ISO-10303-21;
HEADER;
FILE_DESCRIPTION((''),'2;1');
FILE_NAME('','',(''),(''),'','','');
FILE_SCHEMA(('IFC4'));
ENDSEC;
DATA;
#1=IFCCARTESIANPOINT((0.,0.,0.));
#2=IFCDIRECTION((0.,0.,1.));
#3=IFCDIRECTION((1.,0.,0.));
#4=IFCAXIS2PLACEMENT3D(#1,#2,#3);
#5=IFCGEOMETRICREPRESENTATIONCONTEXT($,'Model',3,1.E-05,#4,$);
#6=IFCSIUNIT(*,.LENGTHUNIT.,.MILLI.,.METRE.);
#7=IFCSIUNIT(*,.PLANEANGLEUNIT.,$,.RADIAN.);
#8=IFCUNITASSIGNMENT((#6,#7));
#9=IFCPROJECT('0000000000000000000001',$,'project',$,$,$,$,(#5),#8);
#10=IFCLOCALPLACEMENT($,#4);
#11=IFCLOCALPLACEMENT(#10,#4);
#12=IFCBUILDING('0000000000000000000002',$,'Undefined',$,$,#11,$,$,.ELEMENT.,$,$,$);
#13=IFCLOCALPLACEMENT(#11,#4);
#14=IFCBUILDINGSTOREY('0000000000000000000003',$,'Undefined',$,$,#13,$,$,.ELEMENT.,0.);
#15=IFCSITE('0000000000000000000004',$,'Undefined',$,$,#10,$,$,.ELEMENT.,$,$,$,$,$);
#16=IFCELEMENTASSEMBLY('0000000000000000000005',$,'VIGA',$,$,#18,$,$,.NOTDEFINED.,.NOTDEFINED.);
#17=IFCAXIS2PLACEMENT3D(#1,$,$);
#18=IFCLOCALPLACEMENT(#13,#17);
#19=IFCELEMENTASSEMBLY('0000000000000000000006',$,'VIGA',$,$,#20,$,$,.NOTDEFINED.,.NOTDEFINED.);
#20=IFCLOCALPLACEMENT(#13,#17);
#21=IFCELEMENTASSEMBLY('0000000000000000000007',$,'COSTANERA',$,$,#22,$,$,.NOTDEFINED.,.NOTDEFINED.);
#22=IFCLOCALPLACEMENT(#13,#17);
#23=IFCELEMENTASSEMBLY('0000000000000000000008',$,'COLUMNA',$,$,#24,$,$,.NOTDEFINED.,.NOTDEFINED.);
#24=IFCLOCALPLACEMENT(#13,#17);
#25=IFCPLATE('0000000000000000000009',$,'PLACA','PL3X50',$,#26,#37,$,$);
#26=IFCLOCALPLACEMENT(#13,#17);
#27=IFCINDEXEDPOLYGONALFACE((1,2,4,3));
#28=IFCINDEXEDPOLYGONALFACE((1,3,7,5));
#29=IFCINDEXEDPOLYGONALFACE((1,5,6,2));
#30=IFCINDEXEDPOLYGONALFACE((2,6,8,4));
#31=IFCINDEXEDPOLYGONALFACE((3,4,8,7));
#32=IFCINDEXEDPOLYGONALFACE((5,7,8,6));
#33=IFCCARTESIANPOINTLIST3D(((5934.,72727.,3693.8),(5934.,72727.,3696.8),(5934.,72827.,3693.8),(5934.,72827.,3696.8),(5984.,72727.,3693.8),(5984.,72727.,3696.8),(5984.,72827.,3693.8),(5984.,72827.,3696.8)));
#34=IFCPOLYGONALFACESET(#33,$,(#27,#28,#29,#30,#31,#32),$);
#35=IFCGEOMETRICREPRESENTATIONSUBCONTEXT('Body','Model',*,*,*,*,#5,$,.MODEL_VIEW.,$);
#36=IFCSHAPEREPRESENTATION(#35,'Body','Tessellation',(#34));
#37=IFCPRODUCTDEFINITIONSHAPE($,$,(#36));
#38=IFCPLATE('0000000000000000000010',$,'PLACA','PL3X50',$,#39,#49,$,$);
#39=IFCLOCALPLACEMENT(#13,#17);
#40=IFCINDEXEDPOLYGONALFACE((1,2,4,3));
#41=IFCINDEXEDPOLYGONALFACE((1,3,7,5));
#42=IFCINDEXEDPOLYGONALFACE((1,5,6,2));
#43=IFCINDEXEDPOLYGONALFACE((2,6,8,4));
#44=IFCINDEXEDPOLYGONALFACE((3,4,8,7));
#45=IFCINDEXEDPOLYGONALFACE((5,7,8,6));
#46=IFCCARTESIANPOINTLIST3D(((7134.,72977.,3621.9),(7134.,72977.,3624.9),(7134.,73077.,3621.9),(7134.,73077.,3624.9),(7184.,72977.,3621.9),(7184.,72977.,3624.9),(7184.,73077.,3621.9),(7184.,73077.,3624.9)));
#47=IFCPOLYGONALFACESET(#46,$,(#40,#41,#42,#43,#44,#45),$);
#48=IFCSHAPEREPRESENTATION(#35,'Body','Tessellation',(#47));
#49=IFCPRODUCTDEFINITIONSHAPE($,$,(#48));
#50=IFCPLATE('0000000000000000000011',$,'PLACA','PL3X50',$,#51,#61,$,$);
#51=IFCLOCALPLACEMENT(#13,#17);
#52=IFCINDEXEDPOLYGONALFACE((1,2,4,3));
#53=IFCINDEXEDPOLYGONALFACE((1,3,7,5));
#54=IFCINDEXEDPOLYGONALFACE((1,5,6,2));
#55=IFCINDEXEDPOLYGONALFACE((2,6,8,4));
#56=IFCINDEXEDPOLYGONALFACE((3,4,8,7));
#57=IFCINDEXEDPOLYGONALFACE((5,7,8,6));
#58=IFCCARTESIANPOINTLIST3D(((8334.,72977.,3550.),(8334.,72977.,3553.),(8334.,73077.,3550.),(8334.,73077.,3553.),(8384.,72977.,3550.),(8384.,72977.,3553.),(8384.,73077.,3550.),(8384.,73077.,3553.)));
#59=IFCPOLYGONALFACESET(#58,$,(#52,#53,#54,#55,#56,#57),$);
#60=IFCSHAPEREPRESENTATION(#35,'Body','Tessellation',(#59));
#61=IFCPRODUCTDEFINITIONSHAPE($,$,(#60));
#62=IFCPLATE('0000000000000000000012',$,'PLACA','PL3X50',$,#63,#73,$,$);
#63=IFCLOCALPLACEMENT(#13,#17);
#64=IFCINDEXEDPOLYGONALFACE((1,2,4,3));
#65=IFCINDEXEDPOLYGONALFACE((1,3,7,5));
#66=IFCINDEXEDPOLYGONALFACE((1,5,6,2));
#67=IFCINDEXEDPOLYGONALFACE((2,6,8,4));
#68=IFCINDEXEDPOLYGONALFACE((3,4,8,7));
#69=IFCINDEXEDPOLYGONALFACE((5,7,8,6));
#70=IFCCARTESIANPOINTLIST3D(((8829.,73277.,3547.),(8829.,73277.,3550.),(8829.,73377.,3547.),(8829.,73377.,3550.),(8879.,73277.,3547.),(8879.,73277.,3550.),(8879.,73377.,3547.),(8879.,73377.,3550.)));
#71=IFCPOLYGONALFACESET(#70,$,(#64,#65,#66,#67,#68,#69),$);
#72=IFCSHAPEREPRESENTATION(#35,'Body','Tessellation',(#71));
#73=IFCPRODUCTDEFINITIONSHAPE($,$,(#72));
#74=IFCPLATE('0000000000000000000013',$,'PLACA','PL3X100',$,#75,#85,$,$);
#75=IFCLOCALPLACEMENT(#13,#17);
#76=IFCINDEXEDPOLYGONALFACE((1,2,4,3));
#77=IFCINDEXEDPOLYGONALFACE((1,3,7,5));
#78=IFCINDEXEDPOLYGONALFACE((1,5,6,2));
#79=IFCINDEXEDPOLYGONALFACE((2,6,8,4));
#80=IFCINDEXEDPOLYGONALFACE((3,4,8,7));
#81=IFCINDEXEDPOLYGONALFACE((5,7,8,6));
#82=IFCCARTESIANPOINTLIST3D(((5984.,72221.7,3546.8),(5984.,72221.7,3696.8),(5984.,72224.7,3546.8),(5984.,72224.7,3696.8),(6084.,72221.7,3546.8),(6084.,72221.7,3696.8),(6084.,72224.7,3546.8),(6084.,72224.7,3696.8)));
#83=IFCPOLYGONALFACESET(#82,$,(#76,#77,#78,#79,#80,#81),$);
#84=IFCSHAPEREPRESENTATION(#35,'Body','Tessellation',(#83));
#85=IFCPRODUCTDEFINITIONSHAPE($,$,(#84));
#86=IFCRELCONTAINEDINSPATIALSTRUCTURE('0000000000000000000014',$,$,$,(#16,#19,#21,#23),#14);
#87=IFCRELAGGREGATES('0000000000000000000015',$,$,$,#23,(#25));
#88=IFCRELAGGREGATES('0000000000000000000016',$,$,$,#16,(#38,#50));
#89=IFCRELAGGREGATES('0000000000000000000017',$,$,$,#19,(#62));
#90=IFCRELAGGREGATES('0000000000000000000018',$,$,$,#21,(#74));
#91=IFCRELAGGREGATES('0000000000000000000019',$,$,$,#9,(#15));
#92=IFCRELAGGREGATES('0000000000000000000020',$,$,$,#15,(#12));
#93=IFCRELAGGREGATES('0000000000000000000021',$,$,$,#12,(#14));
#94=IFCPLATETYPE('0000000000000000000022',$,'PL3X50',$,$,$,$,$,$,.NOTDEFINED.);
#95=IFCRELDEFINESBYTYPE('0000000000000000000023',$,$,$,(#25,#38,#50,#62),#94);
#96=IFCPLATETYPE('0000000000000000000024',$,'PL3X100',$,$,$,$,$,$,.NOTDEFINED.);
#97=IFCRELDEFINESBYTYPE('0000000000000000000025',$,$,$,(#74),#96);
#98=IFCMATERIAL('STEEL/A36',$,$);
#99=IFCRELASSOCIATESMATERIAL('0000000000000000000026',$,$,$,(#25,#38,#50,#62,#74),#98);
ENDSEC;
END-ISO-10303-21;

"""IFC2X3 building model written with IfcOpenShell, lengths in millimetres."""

from ifc_helpers import new_model, si_unit, frame, origin_with_axes, place, context, subcontext, project, spatial, polyline, outline, extrude, material, type_object, element, aggregate, save


model = new_model("IFC2X3")

# Units and contexts
model_context = context("Model", 3, precision=1e-05, world=origin_with_axes())
body_context = subcontext(model_context, "Body", "Model", "MODEL_VIEW")
ifc_project = project(units=[si_unit("LENGTHUNIT", "METRE", prefix="MILLI"), si_unit("PLANEANGLEUNIT", "RADIAN")], contexts=[model_context])

# Site, building, storey
site_placement = place(None, origin_with_axes())
site = spatial("IfcSite", under=ifc_project, at=site_placement, Name="Undefined", CompositionType="ELEMENT")
building_placement = place(site_placement, origin_with_axes())
building = spatial("IfcBuilding", under=site, at=building_placement, Name="Undefined", CompositionType="ELEMENT")
storey_placement = place(building_placement, origin_with_axes())
storey = spatial("IfcBuildingStorey", under=building, at=storey_placement, Name="Undefined", CompositionType="ELEMENT", Elevation=0.0)

# Shared definitions
ifc_material_1 = material(Name="STEEL/A36")

# Element assembly
assembly_1_placement = place(storey_placement, origin_with_axes())
assembly_1 = element("IfcElementAssembly", 1, at=assembly_1_placement, inside=storey, Name="VIGA", AssemblyPlace="NOTDEFINED", PredefinedType="NOTDEFINED")

# Element assemblies
assembly_2_placement = place(storey_placement, origin_with_axes())
assembly_2 = element("IfcElementAssembly", 2, at=assembly_2_placement, inside=storey, Name="VIGA", AssemblyPlace="NOTDEFINED", PredefinedType="NOTDEFINED")
assembly_3_placement = place(storey_placement, origin_with_axes())
assembly_3 = element("IfcElementAssembly", 3, at=assembly_3_placement, inside=storey, Name="COSTANERA", AssemblyPlace="NOTDEFINED", PredefinedType="NOTDEFINED")

# Shared definitions
plate_type_1 = type_object("IfcPlateType", Name="PL3X50", PredefinedType="NOTDEFINED")

# Element assembly, plate
assembly_4_placement = place(storey_placement, origin_with_axes())
assembly_4 = element("IfcElementAssembly", 4, at=assembly_4_placement, inside=storey, Name="COLUMNA", AssemblyPlace="NOTDEFINED", PredefinedType="NOTDEFINED")
plate_1_placement = place(assembly_4_placement, frame((5984.0, 72727.0, 3695.3), z_axis=(0.0, 0.0, -1.0), x_axis=(-1.0, 0.0, 0.0)))
plate_1 = element("IfcPlate", 5, at=plate_1_placement, type_object=plate_type_1, material=ifc_material_1, Name="PLACA", Description="PL3X50", context=body_context, shape_type="SweptSolid", body=[
    extrude(outline(polyline([(0.0, 0.0), (50.0, 0.0), (50.0, 100.0), (0.0, 100.0), (0.0, 0.0)])), frame((0.0, 0.0, -1.5), z_axis=(0.0, 0.0, 1.0), x_axis=(1.0, 0.0, 0.0)), (0.0, 0.0, 1.0), 3.0),
])
aggregate(assembly_4, [plate_1])

# Plates
plate_2_placement = place(assembly_1_placement, frame((7184.0, 72977.0, 3623.4), z_axis=(0.0, 0.0, -1.0), x_axis=(-1.0, 0.0, 0.0)))
plate_2 = element("IfcPlate", 6, at=plate_2_placement, type_object=plate_type_1, material=ifc_material_1, Name="PLACA", Description="PL3X50", context=body_context, shape_type="SweptSolid", body=[
    extrude(outline(polyline([(0.0, 0.0), (50.0, 0.0), (50.0, 100.0), (0.0, 100.0), (0.0, 0.0)])), frame((0.0, 0.0, -1.5), z_axis=(0.0, 0.0, 1.0), x_axis=(1.0, 0.0, 0.0)), (0.0, 0.0, 1.0), 3.0),
])
plate_3_placement = place(assembly_1_placement, frame((8384.0, 72977.0, 3551.5), z_axis=(0.0, 0.0, -1.0), x_axis=(-1.0, 0.0, 0.0)))
plate_3 = element("IfcPlate", 7, at=plate_3_placement, type_object=plate_type_1, material=ifc_material_1, Name="PLACA", Description="PL3X50", context=body_context, shape_type="SweptSolid", body=[
    extrude(outline(polyline([(0.0, 0.0), (50.0, 0.0), (50.0, 100.0), (0.0, 100.0), (0.0, 0.0)])), frame((0.0, 0.0, -1.5), z_axis=(0.0, 0.0, 1.0), x_axis=(1.0, 0.0, 0.0)), (0.0, 0.0, 1.0), 3.0),
])
aggregate(assembly_1, [plate_2, plate_3])
plate_4_placement = place(assembly_2_placement, frame((8879.0, 73277.0, 3548.5), z_axis=(0.0, 0.0, -1.0), x_axis=(-1.0, 0.0, 0.0)))
plate_4 = element("IfcPlate", 8, at=plate_4_placement, type_object=plate_type_1, material=ifc_material_1, Name="PLACA", Description="PL3X50", context=body_context, shape_type="SweptSolid", body=[
    extrude(outline(polyline([(0.0, 0.0), (50.0, 0.0), (50.0, 100.0), (0.0, 100.0), (0.0, 0.0)])), frame((0.0, 0.0, -1.5), z_axis=(0.0, 0.0, 1.0), x_axis=(1.0, 0.0, 0.0)), (0.0, 0.0, 1.0), 3.0),
])
aggregate(assembly_2, [plate_4])
plate_type_2 = type_object("IfcPlateType", Name="PL3X100", PredefinedType="NOTDEFINED")
plate_5_placement = place(assembly_3_placement, frame((6084.0, 72223.2, 3546.8), z_axis=(0.0, 1.0, 0.0), x_axis=(-1.0, 0.0, 0.0)))
plate_5 = element("IfcPlate", 9, at=plate_5_placement, type_object=plate_type_2, material=ifc_material_1, Name="PLACA", Description="PL3X100", context=body_context, shape_type="SweptSolid", body=[
    extrude(outline(polyline([(0.0, 0.0), (100.0, 0.0), (100.0, 150.0), (0.0, 150.0), (0.0, 0.0)])), frame((0.0, 0.0, -1.5), z_axis=(0.0, 0.0, 1.0), x_axis=(1.0, 0.0, 0.0)), (0.0, 0.0, 1.0), 3.0),
])

aggregate(assembly_3, [plate_5])

save(model, "model.ifc")
